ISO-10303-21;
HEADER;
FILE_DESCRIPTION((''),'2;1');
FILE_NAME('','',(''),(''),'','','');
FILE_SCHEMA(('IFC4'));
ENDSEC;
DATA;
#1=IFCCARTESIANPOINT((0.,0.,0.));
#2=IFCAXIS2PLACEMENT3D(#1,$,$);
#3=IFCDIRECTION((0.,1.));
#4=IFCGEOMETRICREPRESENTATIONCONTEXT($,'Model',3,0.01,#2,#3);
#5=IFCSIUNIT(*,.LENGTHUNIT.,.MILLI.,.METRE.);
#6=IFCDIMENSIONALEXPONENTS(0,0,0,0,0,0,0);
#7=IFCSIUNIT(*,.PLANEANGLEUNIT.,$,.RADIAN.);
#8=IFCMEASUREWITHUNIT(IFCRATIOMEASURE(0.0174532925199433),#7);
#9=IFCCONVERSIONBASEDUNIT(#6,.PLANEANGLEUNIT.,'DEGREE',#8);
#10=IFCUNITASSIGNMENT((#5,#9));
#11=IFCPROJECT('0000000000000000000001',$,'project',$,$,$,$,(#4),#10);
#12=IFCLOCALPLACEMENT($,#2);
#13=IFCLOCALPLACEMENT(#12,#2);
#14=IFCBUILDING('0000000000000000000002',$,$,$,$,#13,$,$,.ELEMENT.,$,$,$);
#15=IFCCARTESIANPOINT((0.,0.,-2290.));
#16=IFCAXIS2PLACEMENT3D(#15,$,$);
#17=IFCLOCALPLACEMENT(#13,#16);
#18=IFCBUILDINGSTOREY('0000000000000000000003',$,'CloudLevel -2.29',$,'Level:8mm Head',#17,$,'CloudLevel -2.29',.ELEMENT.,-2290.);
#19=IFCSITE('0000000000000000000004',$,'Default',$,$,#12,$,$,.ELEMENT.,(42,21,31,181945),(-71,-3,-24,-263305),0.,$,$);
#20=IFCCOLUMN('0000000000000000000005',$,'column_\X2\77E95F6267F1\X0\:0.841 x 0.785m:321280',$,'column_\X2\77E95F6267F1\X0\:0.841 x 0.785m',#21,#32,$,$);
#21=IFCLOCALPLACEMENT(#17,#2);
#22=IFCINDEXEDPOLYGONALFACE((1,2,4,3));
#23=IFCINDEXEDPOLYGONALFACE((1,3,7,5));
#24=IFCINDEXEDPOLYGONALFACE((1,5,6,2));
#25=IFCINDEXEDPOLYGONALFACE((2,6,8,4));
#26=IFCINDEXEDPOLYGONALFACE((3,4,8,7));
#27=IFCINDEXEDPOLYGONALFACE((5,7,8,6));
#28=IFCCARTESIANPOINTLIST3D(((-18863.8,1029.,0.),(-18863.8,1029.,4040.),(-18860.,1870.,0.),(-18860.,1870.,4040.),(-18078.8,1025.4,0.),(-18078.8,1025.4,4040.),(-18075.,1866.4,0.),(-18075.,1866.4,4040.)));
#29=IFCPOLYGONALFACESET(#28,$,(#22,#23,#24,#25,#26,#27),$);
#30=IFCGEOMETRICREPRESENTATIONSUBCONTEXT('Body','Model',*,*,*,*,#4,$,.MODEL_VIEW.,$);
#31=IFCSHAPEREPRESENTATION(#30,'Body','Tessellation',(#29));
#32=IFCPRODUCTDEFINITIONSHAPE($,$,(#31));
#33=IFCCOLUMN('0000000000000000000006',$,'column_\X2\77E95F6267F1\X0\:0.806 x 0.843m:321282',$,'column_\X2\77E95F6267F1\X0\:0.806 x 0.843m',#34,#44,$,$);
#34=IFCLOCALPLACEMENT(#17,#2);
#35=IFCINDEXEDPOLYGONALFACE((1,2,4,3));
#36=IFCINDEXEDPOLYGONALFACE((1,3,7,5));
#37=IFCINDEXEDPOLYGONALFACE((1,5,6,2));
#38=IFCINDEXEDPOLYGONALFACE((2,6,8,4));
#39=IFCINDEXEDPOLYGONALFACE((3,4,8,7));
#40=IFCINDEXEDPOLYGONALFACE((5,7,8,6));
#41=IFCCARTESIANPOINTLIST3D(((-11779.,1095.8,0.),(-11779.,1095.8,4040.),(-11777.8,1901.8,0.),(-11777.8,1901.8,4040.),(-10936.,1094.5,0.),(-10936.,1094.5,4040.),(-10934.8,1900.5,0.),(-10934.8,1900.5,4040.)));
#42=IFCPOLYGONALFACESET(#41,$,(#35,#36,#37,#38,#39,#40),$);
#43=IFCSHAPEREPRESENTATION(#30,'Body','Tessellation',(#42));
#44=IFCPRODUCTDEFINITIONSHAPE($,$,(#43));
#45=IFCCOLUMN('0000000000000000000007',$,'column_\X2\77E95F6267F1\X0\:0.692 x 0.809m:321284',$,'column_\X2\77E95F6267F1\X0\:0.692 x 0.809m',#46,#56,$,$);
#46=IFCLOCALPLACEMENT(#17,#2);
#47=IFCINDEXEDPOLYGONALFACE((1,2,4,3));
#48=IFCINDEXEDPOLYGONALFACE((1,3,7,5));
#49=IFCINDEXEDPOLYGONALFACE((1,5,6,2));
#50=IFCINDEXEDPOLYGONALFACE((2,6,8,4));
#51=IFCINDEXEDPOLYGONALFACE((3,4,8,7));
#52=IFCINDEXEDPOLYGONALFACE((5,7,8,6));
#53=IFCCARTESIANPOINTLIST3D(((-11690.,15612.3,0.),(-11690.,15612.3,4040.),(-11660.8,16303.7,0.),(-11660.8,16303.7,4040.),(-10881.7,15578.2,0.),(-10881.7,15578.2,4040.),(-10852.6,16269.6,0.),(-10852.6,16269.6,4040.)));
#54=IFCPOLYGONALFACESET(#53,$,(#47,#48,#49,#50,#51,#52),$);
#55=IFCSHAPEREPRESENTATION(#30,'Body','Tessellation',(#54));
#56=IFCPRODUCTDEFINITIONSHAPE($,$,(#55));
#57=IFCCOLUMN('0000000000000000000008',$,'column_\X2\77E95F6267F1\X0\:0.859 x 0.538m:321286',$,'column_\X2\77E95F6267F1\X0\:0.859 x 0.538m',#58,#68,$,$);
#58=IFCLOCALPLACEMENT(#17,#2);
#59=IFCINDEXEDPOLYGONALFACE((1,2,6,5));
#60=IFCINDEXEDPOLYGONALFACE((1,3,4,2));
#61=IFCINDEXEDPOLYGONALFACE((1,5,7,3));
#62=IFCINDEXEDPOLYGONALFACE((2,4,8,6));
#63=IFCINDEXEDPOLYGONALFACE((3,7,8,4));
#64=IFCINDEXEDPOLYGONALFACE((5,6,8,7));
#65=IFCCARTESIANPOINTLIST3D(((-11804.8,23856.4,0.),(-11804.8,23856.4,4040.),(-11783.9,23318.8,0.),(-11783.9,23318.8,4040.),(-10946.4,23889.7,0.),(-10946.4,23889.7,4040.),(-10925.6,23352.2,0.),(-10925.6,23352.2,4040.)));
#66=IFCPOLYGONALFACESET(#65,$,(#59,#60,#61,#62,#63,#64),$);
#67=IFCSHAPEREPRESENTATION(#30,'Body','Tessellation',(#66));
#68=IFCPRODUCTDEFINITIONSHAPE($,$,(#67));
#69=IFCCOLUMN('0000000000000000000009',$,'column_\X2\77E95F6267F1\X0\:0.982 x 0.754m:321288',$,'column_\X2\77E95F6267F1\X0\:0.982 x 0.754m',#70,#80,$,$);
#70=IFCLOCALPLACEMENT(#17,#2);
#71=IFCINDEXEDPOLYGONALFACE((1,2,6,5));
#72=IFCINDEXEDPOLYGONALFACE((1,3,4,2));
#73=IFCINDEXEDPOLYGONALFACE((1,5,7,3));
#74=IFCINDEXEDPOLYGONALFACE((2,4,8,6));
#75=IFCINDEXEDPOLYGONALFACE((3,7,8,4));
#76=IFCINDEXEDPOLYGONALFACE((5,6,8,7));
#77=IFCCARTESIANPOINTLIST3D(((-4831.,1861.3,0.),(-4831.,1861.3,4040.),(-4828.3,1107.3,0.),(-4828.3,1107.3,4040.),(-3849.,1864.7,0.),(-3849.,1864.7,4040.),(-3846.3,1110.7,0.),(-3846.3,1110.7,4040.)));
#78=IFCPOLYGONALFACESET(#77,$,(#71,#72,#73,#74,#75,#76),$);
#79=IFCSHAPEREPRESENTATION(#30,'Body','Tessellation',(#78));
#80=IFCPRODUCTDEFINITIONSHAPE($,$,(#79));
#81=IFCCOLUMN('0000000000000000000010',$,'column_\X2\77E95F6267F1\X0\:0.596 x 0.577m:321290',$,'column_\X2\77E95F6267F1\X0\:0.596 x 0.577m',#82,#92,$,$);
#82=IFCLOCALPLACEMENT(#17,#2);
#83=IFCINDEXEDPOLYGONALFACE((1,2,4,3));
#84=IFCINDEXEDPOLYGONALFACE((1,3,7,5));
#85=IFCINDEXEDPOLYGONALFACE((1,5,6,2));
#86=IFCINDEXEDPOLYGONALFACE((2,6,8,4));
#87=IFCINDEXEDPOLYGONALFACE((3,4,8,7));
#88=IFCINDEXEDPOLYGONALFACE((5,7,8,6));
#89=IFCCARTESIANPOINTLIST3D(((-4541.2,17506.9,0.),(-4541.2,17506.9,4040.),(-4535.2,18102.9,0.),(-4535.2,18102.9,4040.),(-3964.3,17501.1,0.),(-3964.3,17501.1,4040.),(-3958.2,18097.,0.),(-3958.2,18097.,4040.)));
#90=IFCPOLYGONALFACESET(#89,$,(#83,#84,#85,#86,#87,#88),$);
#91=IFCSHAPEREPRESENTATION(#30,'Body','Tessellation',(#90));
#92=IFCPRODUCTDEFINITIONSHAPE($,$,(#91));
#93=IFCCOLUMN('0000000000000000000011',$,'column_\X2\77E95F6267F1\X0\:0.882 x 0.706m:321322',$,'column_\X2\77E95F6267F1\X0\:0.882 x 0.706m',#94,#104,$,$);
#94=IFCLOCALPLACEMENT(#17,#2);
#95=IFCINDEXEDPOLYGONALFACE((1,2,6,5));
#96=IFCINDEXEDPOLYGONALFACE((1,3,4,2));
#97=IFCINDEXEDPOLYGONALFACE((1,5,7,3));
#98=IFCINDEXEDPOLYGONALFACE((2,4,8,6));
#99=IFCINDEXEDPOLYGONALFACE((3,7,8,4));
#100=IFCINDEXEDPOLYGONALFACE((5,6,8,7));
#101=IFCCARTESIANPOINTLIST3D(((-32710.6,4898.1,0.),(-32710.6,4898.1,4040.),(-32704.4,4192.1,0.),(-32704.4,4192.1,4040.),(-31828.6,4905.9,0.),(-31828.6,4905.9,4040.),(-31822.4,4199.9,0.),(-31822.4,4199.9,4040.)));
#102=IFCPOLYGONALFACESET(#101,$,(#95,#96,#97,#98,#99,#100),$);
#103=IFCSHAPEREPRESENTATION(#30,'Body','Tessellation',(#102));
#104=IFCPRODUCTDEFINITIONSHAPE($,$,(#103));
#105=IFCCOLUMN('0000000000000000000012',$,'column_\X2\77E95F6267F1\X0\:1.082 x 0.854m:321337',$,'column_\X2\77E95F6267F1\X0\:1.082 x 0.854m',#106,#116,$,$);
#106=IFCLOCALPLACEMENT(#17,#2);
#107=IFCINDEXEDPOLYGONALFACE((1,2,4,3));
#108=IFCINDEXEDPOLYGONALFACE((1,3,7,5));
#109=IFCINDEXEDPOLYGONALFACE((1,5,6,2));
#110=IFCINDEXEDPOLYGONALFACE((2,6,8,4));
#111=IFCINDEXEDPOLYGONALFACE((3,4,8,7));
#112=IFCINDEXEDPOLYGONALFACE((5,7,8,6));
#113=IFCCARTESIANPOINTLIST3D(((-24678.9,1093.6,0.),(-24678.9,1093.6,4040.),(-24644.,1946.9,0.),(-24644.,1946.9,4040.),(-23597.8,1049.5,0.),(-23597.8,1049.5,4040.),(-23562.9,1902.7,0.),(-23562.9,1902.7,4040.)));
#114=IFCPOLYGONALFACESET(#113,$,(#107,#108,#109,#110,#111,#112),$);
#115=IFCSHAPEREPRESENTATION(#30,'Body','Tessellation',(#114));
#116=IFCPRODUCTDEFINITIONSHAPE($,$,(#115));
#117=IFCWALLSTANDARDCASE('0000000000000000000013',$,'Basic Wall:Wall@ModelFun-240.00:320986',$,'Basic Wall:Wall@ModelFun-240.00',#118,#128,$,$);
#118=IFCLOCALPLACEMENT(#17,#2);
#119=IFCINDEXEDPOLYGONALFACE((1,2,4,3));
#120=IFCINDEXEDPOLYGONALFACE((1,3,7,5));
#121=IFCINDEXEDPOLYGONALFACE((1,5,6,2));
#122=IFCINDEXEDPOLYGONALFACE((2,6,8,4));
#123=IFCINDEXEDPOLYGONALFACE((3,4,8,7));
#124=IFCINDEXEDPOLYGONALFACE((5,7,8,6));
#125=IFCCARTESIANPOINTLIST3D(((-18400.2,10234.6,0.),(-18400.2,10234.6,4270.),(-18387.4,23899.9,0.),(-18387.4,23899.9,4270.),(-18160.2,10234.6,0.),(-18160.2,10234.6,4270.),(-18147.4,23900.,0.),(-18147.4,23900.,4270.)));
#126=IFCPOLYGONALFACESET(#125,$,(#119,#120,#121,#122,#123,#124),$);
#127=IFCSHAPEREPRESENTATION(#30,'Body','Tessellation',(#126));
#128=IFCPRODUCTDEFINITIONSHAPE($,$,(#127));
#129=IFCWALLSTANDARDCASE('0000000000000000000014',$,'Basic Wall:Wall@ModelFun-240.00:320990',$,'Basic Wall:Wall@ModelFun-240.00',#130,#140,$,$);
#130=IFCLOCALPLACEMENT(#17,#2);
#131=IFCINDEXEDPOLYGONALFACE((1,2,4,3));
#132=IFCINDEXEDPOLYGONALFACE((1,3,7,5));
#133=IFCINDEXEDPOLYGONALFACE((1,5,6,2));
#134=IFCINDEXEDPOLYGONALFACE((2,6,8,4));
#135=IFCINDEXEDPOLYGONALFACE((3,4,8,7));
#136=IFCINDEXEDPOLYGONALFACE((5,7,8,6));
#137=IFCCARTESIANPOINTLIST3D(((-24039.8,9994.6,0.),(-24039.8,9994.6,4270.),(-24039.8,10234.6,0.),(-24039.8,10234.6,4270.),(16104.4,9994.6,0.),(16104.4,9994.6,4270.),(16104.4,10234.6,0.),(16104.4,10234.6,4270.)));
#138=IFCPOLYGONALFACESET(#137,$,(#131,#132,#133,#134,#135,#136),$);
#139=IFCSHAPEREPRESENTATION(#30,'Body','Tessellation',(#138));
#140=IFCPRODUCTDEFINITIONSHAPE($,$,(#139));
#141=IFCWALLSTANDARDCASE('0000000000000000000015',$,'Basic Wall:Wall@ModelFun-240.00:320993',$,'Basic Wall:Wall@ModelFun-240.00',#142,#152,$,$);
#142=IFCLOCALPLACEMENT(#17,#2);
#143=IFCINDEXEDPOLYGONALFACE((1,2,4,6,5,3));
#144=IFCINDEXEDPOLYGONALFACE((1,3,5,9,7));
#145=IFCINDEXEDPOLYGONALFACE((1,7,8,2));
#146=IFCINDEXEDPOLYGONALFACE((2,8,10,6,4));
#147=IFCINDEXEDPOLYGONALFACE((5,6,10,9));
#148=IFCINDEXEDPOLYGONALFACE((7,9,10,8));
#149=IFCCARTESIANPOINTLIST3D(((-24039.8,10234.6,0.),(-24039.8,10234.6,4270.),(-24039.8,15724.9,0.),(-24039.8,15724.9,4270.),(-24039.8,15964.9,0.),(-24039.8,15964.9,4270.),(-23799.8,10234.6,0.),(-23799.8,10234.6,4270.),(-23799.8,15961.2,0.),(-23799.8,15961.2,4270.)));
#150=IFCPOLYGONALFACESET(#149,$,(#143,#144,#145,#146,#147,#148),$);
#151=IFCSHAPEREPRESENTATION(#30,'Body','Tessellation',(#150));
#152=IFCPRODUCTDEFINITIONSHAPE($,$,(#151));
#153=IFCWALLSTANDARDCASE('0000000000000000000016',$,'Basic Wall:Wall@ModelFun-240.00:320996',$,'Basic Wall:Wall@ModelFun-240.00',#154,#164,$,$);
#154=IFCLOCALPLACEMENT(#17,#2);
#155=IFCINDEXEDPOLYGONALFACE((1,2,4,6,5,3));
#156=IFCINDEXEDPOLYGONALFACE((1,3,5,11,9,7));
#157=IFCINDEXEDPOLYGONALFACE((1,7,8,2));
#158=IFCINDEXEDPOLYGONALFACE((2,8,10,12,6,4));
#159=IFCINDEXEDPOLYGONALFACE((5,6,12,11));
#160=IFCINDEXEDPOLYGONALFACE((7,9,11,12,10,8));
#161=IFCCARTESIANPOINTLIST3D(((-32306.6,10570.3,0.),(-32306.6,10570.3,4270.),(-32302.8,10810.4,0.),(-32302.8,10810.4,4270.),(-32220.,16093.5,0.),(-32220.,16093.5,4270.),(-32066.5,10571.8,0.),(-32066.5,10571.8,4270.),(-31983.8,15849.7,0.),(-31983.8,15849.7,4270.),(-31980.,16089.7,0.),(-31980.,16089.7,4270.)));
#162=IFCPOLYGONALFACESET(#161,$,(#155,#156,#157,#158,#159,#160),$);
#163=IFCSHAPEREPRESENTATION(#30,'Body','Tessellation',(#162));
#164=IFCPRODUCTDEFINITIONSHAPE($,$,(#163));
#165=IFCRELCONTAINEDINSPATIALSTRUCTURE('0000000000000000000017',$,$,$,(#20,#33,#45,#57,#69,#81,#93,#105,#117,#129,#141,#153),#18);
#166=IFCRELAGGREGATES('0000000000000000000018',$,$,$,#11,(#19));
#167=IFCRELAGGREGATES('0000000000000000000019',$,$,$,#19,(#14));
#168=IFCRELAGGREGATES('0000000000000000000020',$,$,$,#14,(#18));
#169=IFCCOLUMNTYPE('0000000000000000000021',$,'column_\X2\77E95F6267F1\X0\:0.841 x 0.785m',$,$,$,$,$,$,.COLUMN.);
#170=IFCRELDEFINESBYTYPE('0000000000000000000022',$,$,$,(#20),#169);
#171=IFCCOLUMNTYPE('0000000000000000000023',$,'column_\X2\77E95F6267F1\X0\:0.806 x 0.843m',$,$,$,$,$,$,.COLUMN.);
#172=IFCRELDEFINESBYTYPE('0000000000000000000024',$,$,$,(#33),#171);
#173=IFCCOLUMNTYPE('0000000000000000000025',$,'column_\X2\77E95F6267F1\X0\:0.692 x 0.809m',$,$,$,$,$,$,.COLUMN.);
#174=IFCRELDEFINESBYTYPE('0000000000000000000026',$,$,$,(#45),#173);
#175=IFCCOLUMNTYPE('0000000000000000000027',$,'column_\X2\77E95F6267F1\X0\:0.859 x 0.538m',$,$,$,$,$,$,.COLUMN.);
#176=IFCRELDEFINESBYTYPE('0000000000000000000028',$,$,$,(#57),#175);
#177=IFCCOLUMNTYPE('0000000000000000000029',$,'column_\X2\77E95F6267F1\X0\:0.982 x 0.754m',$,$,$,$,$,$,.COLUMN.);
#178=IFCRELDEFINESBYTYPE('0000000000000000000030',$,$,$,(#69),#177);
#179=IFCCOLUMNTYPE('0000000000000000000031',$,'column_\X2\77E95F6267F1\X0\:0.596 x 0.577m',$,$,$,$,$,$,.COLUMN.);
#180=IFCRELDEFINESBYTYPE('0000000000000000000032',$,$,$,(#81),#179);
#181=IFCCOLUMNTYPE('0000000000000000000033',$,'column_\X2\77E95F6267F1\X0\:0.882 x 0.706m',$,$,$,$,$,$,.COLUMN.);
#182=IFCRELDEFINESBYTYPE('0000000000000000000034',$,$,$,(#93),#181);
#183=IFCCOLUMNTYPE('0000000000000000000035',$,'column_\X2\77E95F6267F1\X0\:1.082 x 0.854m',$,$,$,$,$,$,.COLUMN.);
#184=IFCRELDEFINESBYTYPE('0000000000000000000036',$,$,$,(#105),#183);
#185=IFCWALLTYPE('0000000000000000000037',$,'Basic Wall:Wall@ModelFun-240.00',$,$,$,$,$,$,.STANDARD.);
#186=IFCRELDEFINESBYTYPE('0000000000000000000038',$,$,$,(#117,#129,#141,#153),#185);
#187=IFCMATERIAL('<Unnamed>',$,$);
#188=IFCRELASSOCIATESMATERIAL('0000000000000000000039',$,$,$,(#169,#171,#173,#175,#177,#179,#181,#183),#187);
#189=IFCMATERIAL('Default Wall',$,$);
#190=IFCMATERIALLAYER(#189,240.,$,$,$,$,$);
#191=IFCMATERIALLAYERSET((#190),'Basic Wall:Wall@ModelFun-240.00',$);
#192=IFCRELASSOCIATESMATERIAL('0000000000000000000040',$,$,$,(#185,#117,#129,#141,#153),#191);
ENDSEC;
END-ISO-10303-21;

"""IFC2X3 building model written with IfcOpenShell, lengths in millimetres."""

from ifc_helpers import new_model, entity, si_unit, converted_unit, direction, frame, frame_2d, origin, origin_2d_with_axis, place, context, subcontext, project, spatial, polyline, rectangle, outline, extrude, source, transform, mapped, material, layer, layer_set, layer_usage, type_object, type_shapes, element, save


model = new_model("IFC2X3")

# Units and contexts
model_context = context("Model", 3, precision=0.01, world=origin(), true_north=direction((0.0, 1.0)))
body_context = subcontext(model_context, "Body", "Model", "MODEL_VIEW")
ifc_project = project(units=[si_unit("LENGTHUNIT", "METRE", prefix="MILLI"), converted_unit("PLANEANGLEUNIT", "DEGREE", entity("IfcRatioMeasure", 0.0174532925199433), si_unit("PLANEANGLEUNIT", "RADIAN"), dimensions=[0, 0, 0, 0, 0, 0, 0])], contexts=[model_context])

# Site, building, storey
site_placement = place(None, origin())
site = spatial("IfcSite", under=ifc_project, at=site_placement, Name="Default", CompositionType="ELEMENT", RefLatitude=(42, 21, 31, 181945), RefLongitude=(-71, -3, -24, -263305), RefElevation=0.0)
building_placement = place(site_placement, origin())
building = spatial("IfcBuilding", under=site, at=building_placement, CompositionType="ELEMENT")
storey_placement = place(building_placement, frame((0.0, 0.0, -2290.0)))
storey = spatial("IfcBuildingStorey", under=building, at=storey_placement, Name="CloudLevel -2.29", ObjectType="Level:8mm Head", LongName="CloudLevel -2.29", CompositionType="ELEMENT", Elevation=-2290.0)

# Columns
ifc_material_1 = material(Name="<Unnamed>")
ifc_material_2 = material(Name="Default Wall")
column_type_1 = type_object("IfcColumnType", Name="column_矩形柱:0.841 x 0.785m", PredefinedType="COLUMN", material=ifc_material_1)
shared_shape_1 = source(origin(), body_context, "Body", "SweptSolid", [
    extrude(rectangle(XDim=785.0, YDim=841.0, at=origin_2d_with_axis()), frame((0.0, 0.0, -2290.0), z_axis=(0.0, 0.0, 1.0), x_axis=(0.0, -1.0, 0.0)), (0.0, 0.0, 1.0), 4040.0),
])
type_shapes(column_type_1, [shared_shape_1])
column_1_placement = place(storey_placement, frame((-18469.4, 1447.7, 2290.0), z_axis=(0.0, 0.0, 1.0), x_axis=(0.004527, 0.99999, 0.0)))
element("IfcColumn", 1, at=column_1_placement, inside=storey, type_object=column_type_1, Name="column_矩形柱:0.841 x 0.785m:321280", ObjectType="column_矩形柱:0.841 x 0.785m", context=body_context, shape_type="MappedRepresentation", body=[
    mapped(shared_shape_1, transform((0.0, 0.0, 0.0), scale=1.0)),
])
column_type_2 = type_object("IfcColumnType", Name="column_矩形柱:0.806 x 0.843m", PredefinedType="COLUMN", material=ifc_material_1)
shared_shape_2 = source(origin(), body_context, "Body", "SweptSolid", [
    extrude(rectangle(XDim=843.0, YDim=806.0, at=origin_2d_with_axis()), frame((0.0, 0.0, -2290.0), z_axis=(0.0, 0.0, 1.0), x_axis=(0.0, -1.0, 0.0)), (0.0, 0.0, 1.0), 4040.0),
])
type_shapes(column_type_2, [shared_shape_2])
column_2_placement = place(storey_placement, frame((-11356.9, 1498.2, 2290.0), z_axis=(0.0, 0.0, 1.0), x_axis=(0.001462, 0.999999, 0.0)))
element("IfcColumn", 2, at=column_2_placement, inside=storey, type_object=column_type_2, Name="column_矩形柱:0.806 x 0.843m:321282", ObjectType="column_矩形柱:0.806 x 0.843m", context=body_context, shape_type="MappedRepresentation", body=[
    mapped(shared_shape_2, transform((0.0, 0.0, 0.0), scale=1.0)),
])
column_type_3 = type_object("IfcColumnType", Name="column_矩形柱:0.692 x 0.809m", PredefinedType="COLUMN", material=ifc_material_1)
shared_shape_3 = source(origin(), body_context, "Body", "SweptSolid", [
    extrude(rectangle(XDim=809.0, YDim=692.0, at=origin_2d_with_axis()), frame((0.0, 0.0, -2290.0), z_axis=(0.0, 0.0, 1.0), x_axis=(0.0, -1.0, 0.0)), (0.0, 0.0, 1.0), 4040.0),
])
type_shapes(column_type_3, [shared_shape_3])
column_3_placement = place(storey_placement, frame((-11271.3, 15941.0, 2290.0), z_axis=(0.0, 0.0, 1.0), x_axis=(0.042082, 0.999114, 0.0)))
element("IfcColumn", 3, at=column_3_placement, inside=storey, type_object=column_type_3, Name="column_矩形柱:0.692 x 0.809m:321284", ObjectType="column_矩形柱:0.692 x 0.809m", context=body_context, shape_type="MappedRepresentation", body=[
    mapped(shared_shape_3, transform((0.0, 0.0, 0.0), scale=1.0)),
])
column_type_4 = type_object("IfcColumnType", Name="column_矩形柱:0.859 x 0.538m", PredefinedType="COLUMN", material=ifc_material_1)
shared_shape_4 = source(origin(), body_context, "Body", "SweptSolid", [
    extrude(rectangle(XDim=538.0, YDim=859.0, at=origin_2d_with_axis()), frame((0.0, 0.0, -2290.0), z_axis=(0.0, 0.0, 1.0), x_axis=(0.0, -1.0, 0.0)), (0.0, 0.0, 1.0), 4040.0),
])
type_shapes(column_type_4, [shared_shape_4])
column_4_placement = place(storey_placement, frame((-11365.2, 23604.3, 2290.0), z_axis=(0.0, 0.0, 1.0), x_axis=(0.999247, 0.038789, 0.0)))
element("IfcColumn", 4, at=column_4_placement, inside=storey, type_object=column_type_4, Name="column_矩形柱:0.859 x 0.538m:321286", ObjectType="column_矩形柱:0.859 x 0.538m", context=body_context, shape_type="MappedRepresentation", body=[
    mapped(shared_shape_4, transform((0.0, 0.0, 0.0), scale=1.0)),
])
column_type_5 = type_object("IfcColumnType", Name="column_矩形柱:0.982 x 0.754m", PredefinedType="COLUMN", material=ifc_material_1)
shared_shape_5 = source(origin(), body_context, "Body", "SweptSolid", [
    extrude(rectangle(XDim=754.0, YDim=982.0, at=origin_2d_with_axis()), frame((0.0, 0.0, -2290.0), z_axis=(0.0, 0.0, 1.0), x_axis=(0.0, -1.0, 0.0)), (0.0, 0.0, 1.0), 4040.0),
])
type_shapes(column_type_5, [shared_shape_5])
column_5_placement = place(storey_placement, frame((-4338.7, 1486.0, 2290.0), z_axis=(0.0, 0.0, 1.0), x_axis=(0.999994, 0.003533, 0.0)))
element("IfcColumn", 5, at=column_5_placement, inside=storey, type_object=column_type_5, Name="column_矩形柱:0.982 x 0.754m:321288", ObjectType="column_矩形柱:0.982 x 0.754m", context=body_context, shape_type="MappedRepresentation", body=[
    mapped(shared_shape_5, transform((0.0, 0.0, 0.0), scale=1.0)),
])
column_type_6 = type_object("IfcColumnType", Name="column_矩形柱:0.596 x 0.577m", PredefinedType="COLUMN", material=ifc_material_1)
shared_shape_6 = source(origin(), body_context, "Body", "SweptSolid", [
    extrude(rectangle(XDim=577.0, YDim=596.0, at=origin_2d_with_axis()), frame((0.0, 0.0, -2290.0), z_axis=(0.0, 0.0, 1.0), x_axis=(0.0, -1.0, 0.0)), (0.0, 0.0, 1.0), 4040.0),
])
type_shapes(column_type_6, [shared_shape_6])
column_6_placement = place(storey_placement, frame((-4249.7, 17802.0, 2290.0), z_axis=(0.0, 0.0, 1.0), x_axis=(0.010154, 0.999948, 0.0)))
element("IfcColumn", 6, at=column_6_placement, inside=storey, type_object=column_type_6, Name="column_矩形柱:0.596 x 0.577m:321290", ObjectType="column_矩形柱:0.596 x 0.577m", context=body_context, shape_type="MappedRepresentation", body=[
    mapped(shared_shape_6, transform((0.0, 0.0, 0.0), scale=1.0)),
])
column_type_7 = type_object("IfcColumnType", Name="column_矩形柱:0.882 x 0.706m", PredefinedType="COLUMN", material=ifc_material_1)
shared_shape_7 = source(origin(), body_context, "Body", "SweptSolid", [
    extrude(rectangle(XDim=706.0, YDim=882.0, at=origin_2d_with_axis()), frame((0.0, 0.0, -2290.0), z_axis=(0.0, 0.0, 1.0), x_axis=(0.0, -1.0, 0.0)), (0.0, 0.0, 1.0), 4040.0),
])
type_shapes(column_type_7, [shared_shape_7])
column_7_placement = place(storey_placement, frame((-32266.5, 4549.0, 2290.0), z_axis=(0.0, 0.0, 1.0), x_axis=(0.999961, 0.008846, 0.0)))
element("IfcColumn", 7, at=column_7_placement, inside=storey, type_object=column_type_7, Name="column_矩形柱:0.882 x 0.706m:321322", ObjectType="column_矩形柱:0.882 x 0.706m", context=body_context, shape_type="MappedRepresentation", body=[
    mapped(shared_shape_7, transform((0.0, 0.0, 0.0), scale=1.0)),
])
column_type_8 = type_object("IfcColumnType", Name="column_矩形柱:1.082 x 0.854m", PredefinedType="COLUMN", material=ifc_material_1)
shared_shape_8 = source(origin(), body_context, "Body", "SweptSolid", [
    extrude(rectangle(XDim=854.0, YDim=1082.0, at=origin_2d_with_axis()), frame((0.0, 0.0, -2290.0), z_axis=(0.0, 0.0, 1.0), x_axis=(0.0, -1.0, 0.0)), (0.0, 0.0, 1.0), 4040.0),
])
type_shapes(column_type_8, [shared_shape_8])
column_8_placement = place(storey_placement, frame((-24120.9, 1498.2, 2290.0), z_axis=(0.0, 0.0, 1.0), x_axis=(0.999166, -0.040842, 0.0)))
element("IfcColumn", 8, at=column_8_placement, inside=storey, type_object=column_type_8, Name="column_矩形柱:1.082 x 0.854m:321337", ObjectType="column_矩形柱:1.082 x 0.854m", context=body_context, shape_type="MappedRepresentation", body=[
    mapped(shared_shape_8, transform((0.0, 0.0, 0.0), scale=1.0)),
])

# Walls
ifc_layer = layer(ifc_material_2, 240.0)
ifc_layer_set = layer_set([ifc_layer], Name="Basic Wall:Wall@ModelFun-240.00")
ifc_layer_usage_1 = layer_usage(ifc_layer_set, "AXIS2", "NEGATIVE", 120.0)
wall_type = type_object("IfcWallType", Name="Basic Wall:Wall@ModelFun-240.00", PredefinedType="STANDARD", material=ifc_layer_set)
wall_1_placement = place(storey_placement, frame((-18280.2, 10234.5, 0.0), z_axis=(0.0, 0.0, 1.0), x_axis=(0.000936, 1.0, 0.0)))
element("IfcWallStandardCase", 9, at=wall_1_placement, inside=storey, type_object=wall_type, material=ifc_layer_usage_1, Name="Basic Wall:Wall@ModelFun-240.00:320986", ObjectType="Basic Wall:Wall@ModelFun-240.00", context=body_context, shape_type="SweptSolid", body=[
    extrude(outline(polyline([(13665.6, -120.0), (13665.3, 120.0), (0.0, 120.0), (0.2, -120.0), (13665.6, -120.0)])), origin(), (0.0, 0.0, 1.0), 4270.0),
])
ifc_layer_usage_2 = layer_usage(ifc_layer_set, "AXIS2", "NEGATIVE", 120.0)
wall_2_placement = place(storey_placement, frame((-24039.8, 10114.6, 0.0)))
element("IfcWallStandardCase", 10, at=wall_2_placement, inside=storey, type_object=wall_type, material=ifc_layer_usage_2, Name="Basic Wall:Wall@ModelFun-240.00:320990", ObjectType="Basic Wall:Wall@ModelFun-240.00", context=body_context, shape_type="SweptSolid", body=[
    extrude(rectangle(XDim=40144.2, YDim=240.0, at=frame_2d((20072.1, 0.0), x_axis=(-1.0, 0.0))), origin(), (0.0, 0.0, 1.0), 4270.0),
])
ifc_layer_usage_3 = layer_usage(ifc_layer_set, "AXIS2", "NEGATIVE", 120.0)
wall_3_placement = place(storey_placement, frame((-23919.8, 15964.9, 0.0), z_axis=(0.0, 0.0, 1.0), x_axis=(0.0, -1.0, 0.0)))
element("IfcWallStandardCase", 11, at=wall_3_placement, inside=storey, type_object=wall_type, material=ifc_layer_usage_3, Name="Basic Wall:Wall@ModelFun-240.00:320993", ObjectType="Basic Wall:Wall@ModelFun-240.00", context=body_context, shape_type="SweptSolid", body=[
    extrude(outline(polyline([(5730.3, -120.0), (5730.3, 120.0), (3.8, 120.0), (0.0, -120.0), (240.0, -120.0), (5730.3, -120.0)])), origin(), (0.0, 0.0, 1.0), 4270.0),
])
ifc_layer_usage_4 = layer_usage(ifc_layer_set, "AXIS2", "NEGATIVE", 120.0)
wall_4_placement = place(storey_placement, frame((-32186.6, 10568.5, 0.0), z_axis=(0.0, 0.0, 1.0), x_axis=(0.015672, 0.999877, 0.0)))
element("IfcWallStandardCase", 12, at=wall_4_placement, inside=storey, type_object=wall_type, material=ifc_layer_usage_4, Name="Basic Wall:Wall@ModelFun-240.00:320996", ObjectType="Basic Wall:Wall@ModelFun-240.00", context=body_context, shape_type="SweptSolid", body=[
    extrude(outline(polyline([(5523.8, -120.0), (5523.8, 120.0), (240.1, 120.0), (0.0, 120.0), (5.2, -120.0), (5283.8, -120.0), (5523.8, -120.0)])), origin(), (0.0, 0.0, 1.0), 4270.0),
])

save(model, "model.ifc")
